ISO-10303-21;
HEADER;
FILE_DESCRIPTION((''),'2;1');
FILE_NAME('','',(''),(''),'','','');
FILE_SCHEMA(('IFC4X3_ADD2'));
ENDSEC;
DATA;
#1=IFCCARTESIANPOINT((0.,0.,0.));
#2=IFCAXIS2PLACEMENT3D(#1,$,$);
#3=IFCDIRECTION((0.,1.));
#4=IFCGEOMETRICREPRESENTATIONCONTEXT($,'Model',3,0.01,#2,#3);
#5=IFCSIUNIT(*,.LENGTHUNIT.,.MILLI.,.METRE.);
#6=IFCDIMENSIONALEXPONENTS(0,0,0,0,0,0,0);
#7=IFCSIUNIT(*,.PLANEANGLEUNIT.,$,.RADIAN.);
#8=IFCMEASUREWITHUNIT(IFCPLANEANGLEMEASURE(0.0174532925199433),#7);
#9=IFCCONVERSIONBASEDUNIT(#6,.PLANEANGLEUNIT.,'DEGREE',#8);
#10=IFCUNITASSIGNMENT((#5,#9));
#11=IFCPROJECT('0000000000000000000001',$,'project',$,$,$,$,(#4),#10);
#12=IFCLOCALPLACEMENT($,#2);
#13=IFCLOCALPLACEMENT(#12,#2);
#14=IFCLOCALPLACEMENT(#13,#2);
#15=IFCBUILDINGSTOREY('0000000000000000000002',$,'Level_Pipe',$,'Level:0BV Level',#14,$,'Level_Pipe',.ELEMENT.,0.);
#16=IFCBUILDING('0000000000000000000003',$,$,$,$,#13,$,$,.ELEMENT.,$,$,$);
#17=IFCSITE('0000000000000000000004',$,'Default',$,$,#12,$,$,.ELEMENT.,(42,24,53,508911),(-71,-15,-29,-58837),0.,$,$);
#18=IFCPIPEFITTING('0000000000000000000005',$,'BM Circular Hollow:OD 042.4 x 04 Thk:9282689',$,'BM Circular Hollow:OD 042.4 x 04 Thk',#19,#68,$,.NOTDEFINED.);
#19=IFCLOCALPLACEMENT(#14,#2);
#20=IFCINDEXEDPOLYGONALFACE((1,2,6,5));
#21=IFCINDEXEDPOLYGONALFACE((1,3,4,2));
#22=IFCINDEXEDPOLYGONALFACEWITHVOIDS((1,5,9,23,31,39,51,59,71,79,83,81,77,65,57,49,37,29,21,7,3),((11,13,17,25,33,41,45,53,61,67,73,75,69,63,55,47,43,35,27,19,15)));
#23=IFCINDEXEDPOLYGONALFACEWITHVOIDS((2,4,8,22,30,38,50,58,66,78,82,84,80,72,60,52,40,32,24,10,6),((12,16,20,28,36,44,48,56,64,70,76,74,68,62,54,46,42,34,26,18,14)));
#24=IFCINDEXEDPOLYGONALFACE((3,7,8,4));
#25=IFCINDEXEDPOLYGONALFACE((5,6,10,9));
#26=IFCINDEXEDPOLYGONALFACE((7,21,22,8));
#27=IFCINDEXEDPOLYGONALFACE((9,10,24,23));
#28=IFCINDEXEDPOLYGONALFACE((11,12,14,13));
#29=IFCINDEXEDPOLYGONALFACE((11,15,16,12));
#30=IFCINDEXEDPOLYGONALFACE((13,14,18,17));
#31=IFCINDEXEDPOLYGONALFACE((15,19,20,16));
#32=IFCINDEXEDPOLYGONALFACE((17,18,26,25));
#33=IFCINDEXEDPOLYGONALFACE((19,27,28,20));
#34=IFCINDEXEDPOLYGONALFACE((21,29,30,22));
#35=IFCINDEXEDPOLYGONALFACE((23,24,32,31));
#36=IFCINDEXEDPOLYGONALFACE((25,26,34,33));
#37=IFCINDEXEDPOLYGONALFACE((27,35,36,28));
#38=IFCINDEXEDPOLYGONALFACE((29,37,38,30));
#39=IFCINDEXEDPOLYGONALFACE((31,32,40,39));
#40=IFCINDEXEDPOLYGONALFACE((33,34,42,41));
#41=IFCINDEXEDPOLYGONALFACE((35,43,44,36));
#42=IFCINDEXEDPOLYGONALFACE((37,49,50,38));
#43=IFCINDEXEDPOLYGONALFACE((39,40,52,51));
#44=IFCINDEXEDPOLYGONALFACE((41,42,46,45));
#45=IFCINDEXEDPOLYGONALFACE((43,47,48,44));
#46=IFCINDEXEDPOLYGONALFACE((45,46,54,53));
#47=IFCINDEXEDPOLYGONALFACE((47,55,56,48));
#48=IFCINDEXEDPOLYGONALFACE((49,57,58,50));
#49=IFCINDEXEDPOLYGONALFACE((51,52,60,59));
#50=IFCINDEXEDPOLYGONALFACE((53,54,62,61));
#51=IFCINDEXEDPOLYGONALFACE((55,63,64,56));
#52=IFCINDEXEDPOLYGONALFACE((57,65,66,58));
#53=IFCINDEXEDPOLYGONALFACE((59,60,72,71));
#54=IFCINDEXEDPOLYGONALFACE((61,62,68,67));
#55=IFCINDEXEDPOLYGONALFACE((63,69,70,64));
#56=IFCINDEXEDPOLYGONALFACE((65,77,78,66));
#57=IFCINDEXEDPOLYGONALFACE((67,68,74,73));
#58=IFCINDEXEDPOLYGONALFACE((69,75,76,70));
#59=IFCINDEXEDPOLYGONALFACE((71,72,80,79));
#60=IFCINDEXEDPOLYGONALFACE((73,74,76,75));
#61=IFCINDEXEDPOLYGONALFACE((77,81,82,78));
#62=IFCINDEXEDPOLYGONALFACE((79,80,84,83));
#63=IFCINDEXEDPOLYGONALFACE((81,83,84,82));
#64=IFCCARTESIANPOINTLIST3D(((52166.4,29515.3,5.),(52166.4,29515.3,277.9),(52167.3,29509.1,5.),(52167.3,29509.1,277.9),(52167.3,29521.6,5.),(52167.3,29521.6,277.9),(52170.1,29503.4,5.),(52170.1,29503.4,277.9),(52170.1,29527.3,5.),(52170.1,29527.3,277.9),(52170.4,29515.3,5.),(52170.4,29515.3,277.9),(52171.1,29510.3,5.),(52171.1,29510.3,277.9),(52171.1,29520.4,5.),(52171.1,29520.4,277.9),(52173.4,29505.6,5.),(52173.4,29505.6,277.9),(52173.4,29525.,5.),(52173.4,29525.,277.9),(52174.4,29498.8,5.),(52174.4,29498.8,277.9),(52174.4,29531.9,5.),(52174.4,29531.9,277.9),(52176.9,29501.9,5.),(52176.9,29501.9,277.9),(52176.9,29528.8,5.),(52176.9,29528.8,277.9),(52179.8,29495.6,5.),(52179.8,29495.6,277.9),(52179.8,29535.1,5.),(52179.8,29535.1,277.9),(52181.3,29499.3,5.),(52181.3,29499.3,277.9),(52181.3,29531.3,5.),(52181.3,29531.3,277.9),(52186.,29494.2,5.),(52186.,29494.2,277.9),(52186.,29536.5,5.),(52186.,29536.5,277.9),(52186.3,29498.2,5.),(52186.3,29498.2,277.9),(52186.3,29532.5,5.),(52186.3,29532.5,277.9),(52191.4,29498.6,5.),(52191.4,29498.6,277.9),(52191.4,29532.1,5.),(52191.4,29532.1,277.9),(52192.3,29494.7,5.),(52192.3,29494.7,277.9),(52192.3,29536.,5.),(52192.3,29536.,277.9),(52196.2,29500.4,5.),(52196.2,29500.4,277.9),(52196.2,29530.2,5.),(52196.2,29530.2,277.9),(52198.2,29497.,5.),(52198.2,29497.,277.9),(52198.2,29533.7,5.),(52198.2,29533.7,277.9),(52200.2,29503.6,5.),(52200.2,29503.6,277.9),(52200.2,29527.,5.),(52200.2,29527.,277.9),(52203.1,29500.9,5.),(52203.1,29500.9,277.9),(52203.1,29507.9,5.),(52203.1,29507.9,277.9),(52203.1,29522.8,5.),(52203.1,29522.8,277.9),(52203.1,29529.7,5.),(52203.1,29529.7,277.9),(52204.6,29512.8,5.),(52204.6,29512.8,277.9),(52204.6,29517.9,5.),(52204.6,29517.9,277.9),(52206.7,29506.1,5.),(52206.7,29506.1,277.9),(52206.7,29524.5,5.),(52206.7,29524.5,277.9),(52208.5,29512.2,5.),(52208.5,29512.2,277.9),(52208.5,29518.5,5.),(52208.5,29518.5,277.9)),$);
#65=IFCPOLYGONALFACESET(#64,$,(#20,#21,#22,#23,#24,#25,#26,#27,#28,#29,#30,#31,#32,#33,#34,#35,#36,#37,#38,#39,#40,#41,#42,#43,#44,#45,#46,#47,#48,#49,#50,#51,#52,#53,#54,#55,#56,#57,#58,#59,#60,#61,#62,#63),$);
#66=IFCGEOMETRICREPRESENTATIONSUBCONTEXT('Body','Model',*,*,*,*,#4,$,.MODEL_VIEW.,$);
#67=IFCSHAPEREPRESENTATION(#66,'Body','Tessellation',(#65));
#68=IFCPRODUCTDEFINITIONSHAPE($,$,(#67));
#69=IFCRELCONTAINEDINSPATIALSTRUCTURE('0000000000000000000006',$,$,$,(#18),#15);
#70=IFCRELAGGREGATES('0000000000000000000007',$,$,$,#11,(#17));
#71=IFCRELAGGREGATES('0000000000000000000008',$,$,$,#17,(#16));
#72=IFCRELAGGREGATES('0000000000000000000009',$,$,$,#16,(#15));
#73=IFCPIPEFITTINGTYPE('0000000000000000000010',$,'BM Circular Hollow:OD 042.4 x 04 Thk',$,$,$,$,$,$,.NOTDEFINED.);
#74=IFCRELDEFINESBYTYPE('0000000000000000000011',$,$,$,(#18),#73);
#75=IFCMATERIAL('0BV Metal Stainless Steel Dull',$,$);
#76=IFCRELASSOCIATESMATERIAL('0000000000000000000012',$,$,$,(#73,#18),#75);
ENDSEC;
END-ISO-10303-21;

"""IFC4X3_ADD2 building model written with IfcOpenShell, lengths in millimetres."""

from ifc_helpers import new_model, entity, si_unit, converted_unit, direction, frame, frame_2d, origin, place, context, subcontext, project, spatial, hollow_circle, extrude, source, transform, mapped, material, type_object, type_shapes, element, save


model = new_model("IFC4X3_ADD2")

# Units and contexts
model_context = context("Model", 3, precision=0.01, world=origin(), true_north=direction((0.0, 1.0)))
body_context = subcontext(model_context, "Body", "Model", "MODEL_VIEW")
ifc_project = project(units=[si_unit("LENGTHUNIT", "METRE", prefix="MILLI"), converted_unit("PLANEANGLEUNIT", "DEGREE", entity("IfcPlaneAngleMeasure", 0.0174532925199433), si_unit("PLANEANGLEUNIT", "RADIAN"), dimensions=[0, 0, 0, 0, 0, 0, 0])], contexts=[model_context])

# Site, building, storey
site_placement = place(None, origin())
site = spatial("IfcSite", under=ifc_project, at=site_placement, Name="Default", CompositionType="ELEMENT", RefLatitude=(42, 24, 53, 508911), RefLongitude=(-71, -15, -29, -58837), RefElevation=0.0)
building_placement = place(site_placement, origin())
building = spatial("IfcBuilding", under=site, at=building_placement, CompositionType="ELEMENT")
storey_placement = place(building_placement, origin())
storey = spatial("IfcBuildingStorey", under=building, at=storey_placement, Name="Level_Pipe", ObjectType="Level:0BV Level", LongName="Level_Pipe", CompositionType="ELEMENT", Elevation=0.0)

# Shared definitions
ifc_material_1 = material(Name="0BV Metal Stainless Steel Dull")

# Pipe fitting
pipe_fitting_type_1 = type_object("IfcPipeFittingType", Name="BM Circular Hollow:OD 042.4 x 04 Thk", PredefinedType="NOTDEFINED", material=ifc_material_1)
shared_shape_1 = source(origin(), body_context, "Body", "SweptSolid", [
    extrude(hollow_circle(Radius=21.2, WallThickness=4.0, at=frame_2d((0.0, 0.0), x_axis=(1.0, 0.0))), frame((-136.5, 0.0, 0.0), z_axis=(1.0, 0.0, 0.0), x_axis=(0.0, -1.0, 0.0)), (0.0, 0.0, 1.0), 272.9),
])
type_shapes(pipe_fitting_type_1, [shared_shape_1])
pipe_fitting_1_placement = place(storey_placement, frame((52187.6, 29515.3, 141.5), z_axis=(0.0, 1.0, 0.0), x_axis=(0.0, 0.0, 1.0)))
element("IfcPipeFitting", 1, at=pipe_fitting_1_placement, inside=storey, type_object=pipe_fitting_type_1, material=ifc_material_1, Name="BM Circular Hollow:OD 042.4 x 04 Thk:9282689", ObjectType="BM Circular Hollow:OD 042.4 x 04 Thk", PredefinedType="NOTDEFINED", context=body_context, shape_type="MappedRepresentation", body=[
    mapped(shared_shape_1, transform((0.0, 0.0, 0.0), scale=1.0)),
])

save(model, "model.ifc")
